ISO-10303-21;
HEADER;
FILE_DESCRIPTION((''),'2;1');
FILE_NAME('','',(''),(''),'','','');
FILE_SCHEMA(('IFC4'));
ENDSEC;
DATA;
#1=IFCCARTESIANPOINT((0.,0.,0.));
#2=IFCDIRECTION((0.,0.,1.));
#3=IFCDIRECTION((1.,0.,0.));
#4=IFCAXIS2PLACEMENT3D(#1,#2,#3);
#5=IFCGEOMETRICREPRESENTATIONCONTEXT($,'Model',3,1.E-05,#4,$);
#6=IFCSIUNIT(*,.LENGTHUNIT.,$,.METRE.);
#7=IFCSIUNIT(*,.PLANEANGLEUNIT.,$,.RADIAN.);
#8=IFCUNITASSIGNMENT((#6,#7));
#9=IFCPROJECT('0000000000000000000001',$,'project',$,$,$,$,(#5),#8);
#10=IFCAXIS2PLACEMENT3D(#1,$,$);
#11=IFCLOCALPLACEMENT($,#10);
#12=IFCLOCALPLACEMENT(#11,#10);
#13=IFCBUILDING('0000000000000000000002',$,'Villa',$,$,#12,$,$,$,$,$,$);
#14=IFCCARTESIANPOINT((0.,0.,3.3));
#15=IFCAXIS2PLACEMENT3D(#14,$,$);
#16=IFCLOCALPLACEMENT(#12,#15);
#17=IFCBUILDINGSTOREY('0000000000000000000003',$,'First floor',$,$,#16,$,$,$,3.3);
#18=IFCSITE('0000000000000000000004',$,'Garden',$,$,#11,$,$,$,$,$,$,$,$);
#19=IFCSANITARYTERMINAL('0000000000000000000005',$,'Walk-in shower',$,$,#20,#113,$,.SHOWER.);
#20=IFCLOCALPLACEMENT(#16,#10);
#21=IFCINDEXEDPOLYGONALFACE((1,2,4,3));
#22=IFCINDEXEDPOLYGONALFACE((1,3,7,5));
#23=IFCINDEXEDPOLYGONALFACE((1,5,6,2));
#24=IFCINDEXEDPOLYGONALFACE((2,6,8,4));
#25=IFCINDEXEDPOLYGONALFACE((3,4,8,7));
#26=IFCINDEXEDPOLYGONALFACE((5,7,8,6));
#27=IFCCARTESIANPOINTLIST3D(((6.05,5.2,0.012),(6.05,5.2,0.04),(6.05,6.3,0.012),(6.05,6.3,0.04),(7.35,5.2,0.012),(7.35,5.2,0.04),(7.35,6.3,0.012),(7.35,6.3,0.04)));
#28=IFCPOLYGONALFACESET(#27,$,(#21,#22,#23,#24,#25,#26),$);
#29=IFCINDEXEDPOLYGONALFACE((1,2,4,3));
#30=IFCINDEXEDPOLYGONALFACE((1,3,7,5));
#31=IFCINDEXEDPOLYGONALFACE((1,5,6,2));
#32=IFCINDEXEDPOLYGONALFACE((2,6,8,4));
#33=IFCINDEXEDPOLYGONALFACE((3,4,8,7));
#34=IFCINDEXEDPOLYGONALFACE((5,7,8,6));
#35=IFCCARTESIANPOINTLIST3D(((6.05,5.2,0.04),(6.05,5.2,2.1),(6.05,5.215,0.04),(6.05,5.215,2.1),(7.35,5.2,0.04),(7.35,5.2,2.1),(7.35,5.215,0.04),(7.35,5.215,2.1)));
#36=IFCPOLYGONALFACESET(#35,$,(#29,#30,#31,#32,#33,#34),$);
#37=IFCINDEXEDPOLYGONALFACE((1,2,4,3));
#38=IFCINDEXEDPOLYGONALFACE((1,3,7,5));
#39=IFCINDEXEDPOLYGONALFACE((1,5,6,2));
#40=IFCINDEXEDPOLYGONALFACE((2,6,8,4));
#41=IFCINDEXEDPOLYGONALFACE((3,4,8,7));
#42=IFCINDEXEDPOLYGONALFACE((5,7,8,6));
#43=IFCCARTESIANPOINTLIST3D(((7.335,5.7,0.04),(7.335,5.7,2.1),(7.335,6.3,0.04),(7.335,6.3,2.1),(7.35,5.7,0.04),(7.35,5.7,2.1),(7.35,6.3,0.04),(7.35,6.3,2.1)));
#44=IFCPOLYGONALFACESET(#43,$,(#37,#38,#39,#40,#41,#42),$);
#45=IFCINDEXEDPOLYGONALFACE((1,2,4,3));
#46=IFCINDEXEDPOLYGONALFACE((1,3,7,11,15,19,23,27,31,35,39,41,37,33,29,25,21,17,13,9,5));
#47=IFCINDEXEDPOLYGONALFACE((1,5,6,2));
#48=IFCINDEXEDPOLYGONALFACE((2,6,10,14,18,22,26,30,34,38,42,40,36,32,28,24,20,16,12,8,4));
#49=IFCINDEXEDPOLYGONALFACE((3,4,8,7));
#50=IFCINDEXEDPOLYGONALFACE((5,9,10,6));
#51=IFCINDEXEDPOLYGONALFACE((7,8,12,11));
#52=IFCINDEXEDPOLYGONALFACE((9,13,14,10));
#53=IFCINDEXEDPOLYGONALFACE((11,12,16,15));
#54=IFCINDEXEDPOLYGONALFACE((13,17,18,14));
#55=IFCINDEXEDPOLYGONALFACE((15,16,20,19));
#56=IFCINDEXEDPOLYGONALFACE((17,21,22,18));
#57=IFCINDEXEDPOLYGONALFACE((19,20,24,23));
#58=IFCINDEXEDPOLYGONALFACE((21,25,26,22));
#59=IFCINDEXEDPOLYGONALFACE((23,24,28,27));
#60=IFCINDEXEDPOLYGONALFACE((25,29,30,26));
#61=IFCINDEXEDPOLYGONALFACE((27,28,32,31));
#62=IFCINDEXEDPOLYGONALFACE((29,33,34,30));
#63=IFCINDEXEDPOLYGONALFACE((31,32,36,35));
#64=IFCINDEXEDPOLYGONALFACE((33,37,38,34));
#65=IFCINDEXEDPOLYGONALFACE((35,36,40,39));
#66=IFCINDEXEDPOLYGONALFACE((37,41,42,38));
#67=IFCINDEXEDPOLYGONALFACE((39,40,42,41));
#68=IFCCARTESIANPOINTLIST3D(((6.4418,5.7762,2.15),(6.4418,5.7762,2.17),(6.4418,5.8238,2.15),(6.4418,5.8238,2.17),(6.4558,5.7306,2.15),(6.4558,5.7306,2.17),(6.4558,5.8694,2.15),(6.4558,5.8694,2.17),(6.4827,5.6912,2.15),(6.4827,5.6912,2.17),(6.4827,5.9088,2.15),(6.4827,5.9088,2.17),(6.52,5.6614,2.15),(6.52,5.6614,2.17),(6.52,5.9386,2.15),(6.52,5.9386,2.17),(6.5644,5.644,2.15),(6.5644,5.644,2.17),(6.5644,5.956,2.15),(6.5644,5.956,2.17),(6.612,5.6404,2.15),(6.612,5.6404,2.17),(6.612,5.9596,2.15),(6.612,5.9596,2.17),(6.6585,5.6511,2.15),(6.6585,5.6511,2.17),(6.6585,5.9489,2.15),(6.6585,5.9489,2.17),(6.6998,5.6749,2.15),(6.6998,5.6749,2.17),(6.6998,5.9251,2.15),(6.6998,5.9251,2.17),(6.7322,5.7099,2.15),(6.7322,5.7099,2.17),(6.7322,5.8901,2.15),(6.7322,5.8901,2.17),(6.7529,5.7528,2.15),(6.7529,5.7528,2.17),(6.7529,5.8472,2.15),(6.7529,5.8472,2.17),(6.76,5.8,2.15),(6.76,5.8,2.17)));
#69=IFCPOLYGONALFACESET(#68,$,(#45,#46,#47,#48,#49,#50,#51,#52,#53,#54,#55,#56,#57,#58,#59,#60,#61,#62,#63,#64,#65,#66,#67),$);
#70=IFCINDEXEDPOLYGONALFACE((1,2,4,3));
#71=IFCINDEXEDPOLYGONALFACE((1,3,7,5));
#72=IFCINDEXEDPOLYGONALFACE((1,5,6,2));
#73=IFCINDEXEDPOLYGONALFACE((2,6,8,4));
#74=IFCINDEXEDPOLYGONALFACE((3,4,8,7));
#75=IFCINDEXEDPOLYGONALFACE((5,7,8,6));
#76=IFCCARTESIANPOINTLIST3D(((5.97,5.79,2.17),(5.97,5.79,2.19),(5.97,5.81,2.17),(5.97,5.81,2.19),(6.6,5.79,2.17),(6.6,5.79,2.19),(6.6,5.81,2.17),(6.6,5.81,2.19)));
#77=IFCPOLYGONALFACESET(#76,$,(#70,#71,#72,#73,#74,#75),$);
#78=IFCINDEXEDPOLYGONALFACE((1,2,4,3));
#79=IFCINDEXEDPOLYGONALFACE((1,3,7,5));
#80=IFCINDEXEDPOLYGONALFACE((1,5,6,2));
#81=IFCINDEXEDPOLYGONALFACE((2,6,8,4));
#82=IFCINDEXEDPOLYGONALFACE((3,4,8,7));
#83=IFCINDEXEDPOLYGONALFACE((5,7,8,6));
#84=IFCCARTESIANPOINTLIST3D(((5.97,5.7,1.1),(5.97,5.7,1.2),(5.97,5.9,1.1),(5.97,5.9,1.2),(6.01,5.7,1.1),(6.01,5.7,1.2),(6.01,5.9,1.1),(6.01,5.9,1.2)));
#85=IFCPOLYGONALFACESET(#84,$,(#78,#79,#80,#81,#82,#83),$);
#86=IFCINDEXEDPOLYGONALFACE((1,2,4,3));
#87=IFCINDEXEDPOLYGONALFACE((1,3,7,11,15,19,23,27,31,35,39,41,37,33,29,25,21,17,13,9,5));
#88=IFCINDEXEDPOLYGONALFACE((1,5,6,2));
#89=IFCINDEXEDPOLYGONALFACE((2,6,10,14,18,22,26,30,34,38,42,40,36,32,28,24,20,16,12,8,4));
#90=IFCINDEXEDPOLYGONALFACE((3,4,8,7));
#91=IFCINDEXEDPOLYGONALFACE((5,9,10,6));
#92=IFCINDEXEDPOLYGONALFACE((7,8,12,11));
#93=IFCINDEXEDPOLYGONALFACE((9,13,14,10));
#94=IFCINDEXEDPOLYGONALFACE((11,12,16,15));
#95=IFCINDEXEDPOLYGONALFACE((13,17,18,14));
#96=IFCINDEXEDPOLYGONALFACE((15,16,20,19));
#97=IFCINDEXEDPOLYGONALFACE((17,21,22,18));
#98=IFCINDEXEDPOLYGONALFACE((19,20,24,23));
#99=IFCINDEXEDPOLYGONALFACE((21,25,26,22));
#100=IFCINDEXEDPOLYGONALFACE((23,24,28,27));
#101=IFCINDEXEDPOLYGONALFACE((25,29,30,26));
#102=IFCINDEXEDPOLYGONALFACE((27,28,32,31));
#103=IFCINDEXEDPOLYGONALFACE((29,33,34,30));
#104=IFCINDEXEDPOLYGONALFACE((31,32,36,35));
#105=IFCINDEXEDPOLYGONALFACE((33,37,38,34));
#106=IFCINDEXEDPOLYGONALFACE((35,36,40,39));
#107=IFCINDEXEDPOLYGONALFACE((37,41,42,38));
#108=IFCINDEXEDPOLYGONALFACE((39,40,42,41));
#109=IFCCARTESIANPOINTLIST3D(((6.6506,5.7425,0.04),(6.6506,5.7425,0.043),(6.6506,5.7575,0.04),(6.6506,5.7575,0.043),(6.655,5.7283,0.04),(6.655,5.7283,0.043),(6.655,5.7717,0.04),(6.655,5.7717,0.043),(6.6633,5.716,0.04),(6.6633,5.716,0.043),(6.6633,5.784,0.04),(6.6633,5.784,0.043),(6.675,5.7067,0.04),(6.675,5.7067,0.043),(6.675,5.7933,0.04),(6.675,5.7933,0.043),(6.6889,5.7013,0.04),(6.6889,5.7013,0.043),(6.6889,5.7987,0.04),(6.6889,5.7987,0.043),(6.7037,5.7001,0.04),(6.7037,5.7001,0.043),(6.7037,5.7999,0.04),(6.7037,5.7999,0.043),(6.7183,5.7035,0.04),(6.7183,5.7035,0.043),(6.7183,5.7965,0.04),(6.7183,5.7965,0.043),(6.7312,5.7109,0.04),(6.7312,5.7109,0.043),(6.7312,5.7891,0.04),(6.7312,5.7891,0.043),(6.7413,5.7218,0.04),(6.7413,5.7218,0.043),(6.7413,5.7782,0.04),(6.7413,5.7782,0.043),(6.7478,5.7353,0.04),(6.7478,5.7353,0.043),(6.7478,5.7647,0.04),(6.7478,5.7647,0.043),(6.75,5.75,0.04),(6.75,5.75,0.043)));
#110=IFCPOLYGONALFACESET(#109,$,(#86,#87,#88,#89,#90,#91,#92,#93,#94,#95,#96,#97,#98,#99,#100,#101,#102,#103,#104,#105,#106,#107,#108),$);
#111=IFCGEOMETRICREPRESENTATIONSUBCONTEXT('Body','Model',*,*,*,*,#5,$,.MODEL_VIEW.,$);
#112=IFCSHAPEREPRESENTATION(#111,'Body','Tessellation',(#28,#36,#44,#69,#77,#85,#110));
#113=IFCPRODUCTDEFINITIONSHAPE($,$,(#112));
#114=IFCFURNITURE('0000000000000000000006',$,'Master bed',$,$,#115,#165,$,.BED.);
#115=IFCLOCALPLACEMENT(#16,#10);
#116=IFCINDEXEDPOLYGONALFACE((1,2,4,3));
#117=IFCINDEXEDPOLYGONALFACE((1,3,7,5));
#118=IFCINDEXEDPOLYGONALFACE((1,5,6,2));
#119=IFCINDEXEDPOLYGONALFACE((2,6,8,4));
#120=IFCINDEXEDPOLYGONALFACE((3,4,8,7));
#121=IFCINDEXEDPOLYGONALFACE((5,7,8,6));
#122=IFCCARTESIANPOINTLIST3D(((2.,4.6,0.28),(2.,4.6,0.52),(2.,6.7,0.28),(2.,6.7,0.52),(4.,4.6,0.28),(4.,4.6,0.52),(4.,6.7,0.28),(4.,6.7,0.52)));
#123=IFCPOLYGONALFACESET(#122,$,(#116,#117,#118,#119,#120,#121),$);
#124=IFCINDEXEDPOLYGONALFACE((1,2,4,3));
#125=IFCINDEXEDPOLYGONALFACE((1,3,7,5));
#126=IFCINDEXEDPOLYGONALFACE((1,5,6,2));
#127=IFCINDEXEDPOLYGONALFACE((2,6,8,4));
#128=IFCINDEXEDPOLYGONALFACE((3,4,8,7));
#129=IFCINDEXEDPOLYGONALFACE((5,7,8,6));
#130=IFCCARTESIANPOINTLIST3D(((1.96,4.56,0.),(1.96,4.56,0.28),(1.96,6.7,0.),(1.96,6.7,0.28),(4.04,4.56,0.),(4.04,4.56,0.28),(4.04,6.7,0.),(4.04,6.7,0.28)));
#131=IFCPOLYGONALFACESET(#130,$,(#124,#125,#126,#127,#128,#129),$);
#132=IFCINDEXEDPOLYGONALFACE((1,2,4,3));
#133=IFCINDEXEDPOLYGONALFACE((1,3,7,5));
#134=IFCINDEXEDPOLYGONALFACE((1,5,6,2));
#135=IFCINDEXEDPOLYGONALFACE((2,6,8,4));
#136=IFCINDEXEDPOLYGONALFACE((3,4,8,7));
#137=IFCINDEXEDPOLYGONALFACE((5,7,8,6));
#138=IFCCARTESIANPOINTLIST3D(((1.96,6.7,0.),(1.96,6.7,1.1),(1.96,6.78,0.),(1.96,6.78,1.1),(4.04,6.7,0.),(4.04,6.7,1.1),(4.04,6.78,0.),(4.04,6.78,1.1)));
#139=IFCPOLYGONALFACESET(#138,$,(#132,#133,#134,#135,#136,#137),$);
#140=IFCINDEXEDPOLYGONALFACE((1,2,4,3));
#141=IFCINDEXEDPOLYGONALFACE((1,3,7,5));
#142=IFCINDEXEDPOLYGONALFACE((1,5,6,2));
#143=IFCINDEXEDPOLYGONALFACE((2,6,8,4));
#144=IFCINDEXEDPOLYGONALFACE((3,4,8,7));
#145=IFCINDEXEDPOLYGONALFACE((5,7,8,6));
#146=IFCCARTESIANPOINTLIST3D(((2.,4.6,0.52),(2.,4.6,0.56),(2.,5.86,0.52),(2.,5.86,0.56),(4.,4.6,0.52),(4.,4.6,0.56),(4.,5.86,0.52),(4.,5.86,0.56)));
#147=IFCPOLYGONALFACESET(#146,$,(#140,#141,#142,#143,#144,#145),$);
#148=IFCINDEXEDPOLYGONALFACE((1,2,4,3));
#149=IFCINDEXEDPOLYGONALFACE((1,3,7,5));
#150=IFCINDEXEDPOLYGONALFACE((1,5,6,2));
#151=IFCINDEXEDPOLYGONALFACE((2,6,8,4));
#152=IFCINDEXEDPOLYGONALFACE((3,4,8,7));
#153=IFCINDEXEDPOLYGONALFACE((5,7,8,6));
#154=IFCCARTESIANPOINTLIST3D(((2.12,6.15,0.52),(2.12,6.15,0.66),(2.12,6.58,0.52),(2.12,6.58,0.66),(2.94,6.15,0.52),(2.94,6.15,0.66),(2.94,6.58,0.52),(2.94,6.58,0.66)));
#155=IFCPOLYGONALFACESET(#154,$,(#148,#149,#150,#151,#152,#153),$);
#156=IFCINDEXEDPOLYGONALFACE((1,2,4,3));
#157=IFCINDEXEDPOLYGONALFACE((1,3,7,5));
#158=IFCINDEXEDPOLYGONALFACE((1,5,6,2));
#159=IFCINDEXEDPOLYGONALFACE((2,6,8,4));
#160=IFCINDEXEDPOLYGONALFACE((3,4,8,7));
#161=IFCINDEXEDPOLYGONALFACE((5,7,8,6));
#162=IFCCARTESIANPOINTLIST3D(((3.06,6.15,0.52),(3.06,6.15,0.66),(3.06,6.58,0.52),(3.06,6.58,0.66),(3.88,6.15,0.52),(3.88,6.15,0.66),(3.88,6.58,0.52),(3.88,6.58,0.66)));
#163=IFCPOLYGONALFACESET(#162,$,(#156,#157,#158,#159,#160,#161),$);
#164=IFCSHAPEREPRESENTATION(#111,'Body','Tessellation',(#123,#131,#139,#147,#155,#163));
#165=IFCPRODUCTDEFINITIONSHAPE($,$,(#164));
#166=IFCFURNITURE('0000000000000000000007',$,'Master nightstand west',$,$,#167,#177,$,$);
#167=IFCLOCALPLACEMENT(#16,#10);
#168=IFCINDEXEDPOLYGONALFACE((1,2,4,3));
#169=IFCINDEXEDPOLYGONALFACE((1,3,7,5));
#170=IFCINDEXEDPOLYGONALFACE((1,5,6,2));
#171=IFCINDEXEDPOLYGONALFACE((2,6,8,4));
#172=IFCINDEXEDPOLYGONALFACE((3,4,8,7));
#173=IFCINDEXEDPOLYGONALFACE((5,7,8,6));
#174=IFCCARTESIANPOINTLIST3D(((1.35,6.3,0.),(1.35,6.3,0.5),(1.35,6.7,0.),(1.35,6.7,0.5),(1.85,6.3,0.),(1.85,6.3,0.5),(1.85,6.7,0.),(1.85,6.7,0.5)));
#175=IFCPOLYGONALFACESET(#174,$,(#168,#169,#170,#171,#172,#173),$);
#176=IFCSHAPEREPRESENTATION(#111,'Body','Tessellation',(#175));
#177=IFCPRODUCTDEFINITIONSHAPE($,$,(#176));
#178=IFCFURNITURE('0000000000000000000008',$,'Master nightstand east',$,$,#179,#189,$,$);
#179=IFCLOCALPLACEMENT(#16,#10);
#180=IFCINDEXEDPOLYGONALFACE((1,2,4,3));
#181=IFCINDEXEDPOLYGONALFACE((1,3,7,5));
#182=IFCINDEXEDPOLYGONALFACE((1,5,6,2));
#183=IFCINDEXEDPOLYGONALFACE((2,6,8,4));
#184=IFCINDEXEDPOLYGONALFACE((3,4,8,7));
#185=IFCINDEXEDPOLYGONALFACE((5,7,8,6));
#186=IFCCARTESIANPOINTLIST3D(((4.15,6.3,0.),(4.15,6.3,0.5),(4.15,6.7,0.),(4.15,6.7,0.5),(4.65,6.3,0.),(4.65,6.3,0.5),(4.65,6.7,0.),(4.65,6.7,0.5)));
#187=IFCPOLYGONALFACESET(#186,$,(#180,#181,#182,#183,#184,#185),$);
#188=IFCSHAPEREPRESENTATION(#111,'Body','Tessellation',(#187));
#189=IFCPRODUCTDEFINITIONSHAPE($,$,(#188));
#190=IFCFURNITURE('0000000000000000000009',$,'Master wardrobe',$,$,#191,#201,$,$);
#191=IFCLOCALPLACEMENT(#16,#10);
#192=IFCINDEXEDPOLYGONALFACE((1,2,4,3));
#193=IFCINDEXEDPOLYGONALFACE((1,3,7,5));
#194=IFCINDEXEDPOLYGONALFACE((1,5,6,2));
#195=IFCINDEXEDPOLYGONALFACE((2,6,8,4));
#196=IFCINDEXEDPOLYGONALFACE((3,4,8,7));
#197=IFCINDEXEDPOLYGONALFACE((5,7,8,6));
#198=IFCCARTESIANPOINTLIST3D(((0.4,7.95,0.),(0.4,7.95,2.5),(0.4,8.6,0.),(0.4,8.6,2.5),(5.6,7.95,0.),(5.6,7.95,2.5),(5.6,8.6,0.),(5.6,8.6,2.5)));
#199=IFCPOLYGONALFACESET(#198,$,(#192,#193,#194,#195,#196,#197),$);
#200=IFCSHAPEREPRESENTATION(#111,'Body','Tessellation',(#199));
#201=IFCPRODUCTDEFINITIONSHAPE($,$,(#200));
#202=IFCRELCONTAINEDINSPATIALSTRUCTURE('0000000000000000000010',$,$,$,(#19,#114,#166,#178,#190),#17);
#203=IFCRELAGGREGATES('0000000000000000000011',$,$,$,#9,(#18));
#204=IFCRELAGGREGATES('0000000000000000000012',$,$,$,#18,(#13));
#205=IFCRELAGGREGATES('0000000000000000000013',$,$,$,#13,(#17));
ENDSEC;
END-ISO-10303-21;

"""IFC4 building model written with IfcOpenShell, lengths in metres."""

from ifc_helpers import new_model, si_unit, frame, frame_2d, origin, origin_with_axes, place, context, subcontext, project, spatial, rectangle, circle, extrude, element, save


model = new_model("IFC4")

# Units and contexts
model_context = context("Model", 3, precision=1e-05, world=origin_with_axes())
body_context = subcontext(model_context, "Body", "Model", "MODEL_VIEW")
ifc_project = project(units=[si_unit("LENGTHUNIT", "METRE"), si_unit("PLANEANGLEUNIT", "RADIAN")], contexts=[model_context])

# Site, building, storey
site_placement = place(None, origin())
site = spatial("IfcSite", under=ifc_project, at=site_placement, Name="Garden")
building_placement = place(site_placement, origin())
building = spatial("IfcBuilding", under=site, at=building_placement, Name="Villa")
storey_placement = place(building_placement, frame((0.0, 0.0, 3.3)))
storey = spatial("IfcBuildingStorey", under=building, at=storey_placement, Name="First floor", Elevation=3.3)

# Sanitary terminal
sanitary_terminal_1_placement = place(storey_placement, frame((6.05, 5.2, 0.0)))
element("IfcSanitaryTerminal", 1, at=sanitary_terminal_1_placement, inside=storey, Name="Walk-in shower", PredefinedType="SHOWER", context=body_context, shape_type="SweptSolid", body=[
    extrude(rectangle(XDim=1.3, YDim=1.1, at=frame_2d((0.65, 0.55))), frame((0.0, 0.0, 0.012)), (0.0, 0.0, 1.0), 0.028),
    extrude(rectangle(XDim=1.3, YDim=0.015, at=frame_2d((0.65, 0.0075))), frame((0.0, 0.0, 0.04)), (0.0, 0.0, 1.0), 2.06),
    extrude(rectangle(XDim=0.015, YDim=0.6, at=frame_2d((0.0075, 0.3))), frame((1.285, 0.5, 0.04)), (0.0, 0.0, 1.0), 2.06),
    extrude(circle(Radius=0.16, at=frame_2d((0.55, 0.6))), frame((0.0, 0.0, 2.15)), (0.0, 0.0, 1.0), 0.02),
    extrude(rectangle(XDim=0.63, YDim=0.02, at=frame_2d((0.315, 0.01))), frame((-0.08, 0.59, 2.17)), (0.0, 0.0, 1.0), 0.02),
    extrude(rectangle(XDim=0.04, YDim=0.2, at=frame_2d((0.02, 0.1))), frame((-0.08, 0.5, 1.1)), (0.0, 0.0, 1.0), 0.1),
    extrude(circle(Radius=0.05, at=frame_2d((0.65, 0.55))), frame((0.0, 0.0, 0.04)), (0.0, 0.0, 1.0), 0.003),
])

# Furniture
furniture_1_placement = place(storey_placement, frame((2.0, 4.6, 0.0)))
element("IfcFurniture", 2, at=furniture_1_placement, inside=storey, Name="Master bed", PredefinedType="BED", context=body_context, shape_type="SweptSolid", body=[
    extrude(rectangle(XDim=2.0, YDim=2.1, at=frame_2d((1.0, 1.05))), frame((0.0, 0.0, 0.28)), (0.0, 0.0, 1.0), 0.24),
    extrude(rectangle(XDim=2.08, YDim=2.14, at=frame_2d((1.04, 1.07))), frame((-0.04, -0.04, 0.0)), (0.0, 0.0, 1.0), 0.28),
    extrude(rectangle(XDim=2.08, YDim=0.08, at=frame_2d((1.04, 0.04))), frame((-0.04, 2.1, 0.0)), (0.0, 0.0, 1.0), 1.1),
    extrude(rectangle(XDim=2.0, YDim=1.26, at=frame_2d((1.0, 0.63))), frame((0.0, 0.0, 0.52)), (0.0, 0.0, 1.0), 0.04),
    extrude(rectangle(XDim=0.82, YDim=0.43, at=frame_2d((0.41, 0.215))), frame((0.12, 1.55, 0.52)), (0.0, 0.0, 1.0), 0.14),
    extrude(rectangle(XDim=0.82, YDim=0.43, at=frame_2d((0.41, 0.215))), frame((1.06, 1.55, 0.52)), (0.0, 0.0, 1.0), 0.14),
])
for number, where, name in (
    (3, (1.35, 6.3, 0.0), "Master nightstand west"),
    (4, (4.15, 6.3, 0.0), "Master nightstand east"),
):
    element("IfcFurniture", number, at=place(storey_placement, frame(where)), inside=storey, Name=name, context=body_context, shape_type="SweptSolid", body=[
        extrude(rectangle(XDim=0.5, YDim=0.4, at=frame_2d((0.25, 0.2))), origin(), (0.0, 0.0, 1.0), 0.5),
    ])
furniture_2_placement = place(storey_placement, frame((0.4, 7.95, 0.0)))
element("IfcFurniture", 5, at=furniture_2_placement, inside=storey, Name="Master wardrobe", context=body_context, shape_type="SweptSolid", body=[
    extrude(rectangle(XDim=5.2, YDim=0.65, at=frame_2d((2.6, 0.325))), origin(), (0.0, 0.0, 1.0), 2.5),
])

save(model, "model.ifc")
